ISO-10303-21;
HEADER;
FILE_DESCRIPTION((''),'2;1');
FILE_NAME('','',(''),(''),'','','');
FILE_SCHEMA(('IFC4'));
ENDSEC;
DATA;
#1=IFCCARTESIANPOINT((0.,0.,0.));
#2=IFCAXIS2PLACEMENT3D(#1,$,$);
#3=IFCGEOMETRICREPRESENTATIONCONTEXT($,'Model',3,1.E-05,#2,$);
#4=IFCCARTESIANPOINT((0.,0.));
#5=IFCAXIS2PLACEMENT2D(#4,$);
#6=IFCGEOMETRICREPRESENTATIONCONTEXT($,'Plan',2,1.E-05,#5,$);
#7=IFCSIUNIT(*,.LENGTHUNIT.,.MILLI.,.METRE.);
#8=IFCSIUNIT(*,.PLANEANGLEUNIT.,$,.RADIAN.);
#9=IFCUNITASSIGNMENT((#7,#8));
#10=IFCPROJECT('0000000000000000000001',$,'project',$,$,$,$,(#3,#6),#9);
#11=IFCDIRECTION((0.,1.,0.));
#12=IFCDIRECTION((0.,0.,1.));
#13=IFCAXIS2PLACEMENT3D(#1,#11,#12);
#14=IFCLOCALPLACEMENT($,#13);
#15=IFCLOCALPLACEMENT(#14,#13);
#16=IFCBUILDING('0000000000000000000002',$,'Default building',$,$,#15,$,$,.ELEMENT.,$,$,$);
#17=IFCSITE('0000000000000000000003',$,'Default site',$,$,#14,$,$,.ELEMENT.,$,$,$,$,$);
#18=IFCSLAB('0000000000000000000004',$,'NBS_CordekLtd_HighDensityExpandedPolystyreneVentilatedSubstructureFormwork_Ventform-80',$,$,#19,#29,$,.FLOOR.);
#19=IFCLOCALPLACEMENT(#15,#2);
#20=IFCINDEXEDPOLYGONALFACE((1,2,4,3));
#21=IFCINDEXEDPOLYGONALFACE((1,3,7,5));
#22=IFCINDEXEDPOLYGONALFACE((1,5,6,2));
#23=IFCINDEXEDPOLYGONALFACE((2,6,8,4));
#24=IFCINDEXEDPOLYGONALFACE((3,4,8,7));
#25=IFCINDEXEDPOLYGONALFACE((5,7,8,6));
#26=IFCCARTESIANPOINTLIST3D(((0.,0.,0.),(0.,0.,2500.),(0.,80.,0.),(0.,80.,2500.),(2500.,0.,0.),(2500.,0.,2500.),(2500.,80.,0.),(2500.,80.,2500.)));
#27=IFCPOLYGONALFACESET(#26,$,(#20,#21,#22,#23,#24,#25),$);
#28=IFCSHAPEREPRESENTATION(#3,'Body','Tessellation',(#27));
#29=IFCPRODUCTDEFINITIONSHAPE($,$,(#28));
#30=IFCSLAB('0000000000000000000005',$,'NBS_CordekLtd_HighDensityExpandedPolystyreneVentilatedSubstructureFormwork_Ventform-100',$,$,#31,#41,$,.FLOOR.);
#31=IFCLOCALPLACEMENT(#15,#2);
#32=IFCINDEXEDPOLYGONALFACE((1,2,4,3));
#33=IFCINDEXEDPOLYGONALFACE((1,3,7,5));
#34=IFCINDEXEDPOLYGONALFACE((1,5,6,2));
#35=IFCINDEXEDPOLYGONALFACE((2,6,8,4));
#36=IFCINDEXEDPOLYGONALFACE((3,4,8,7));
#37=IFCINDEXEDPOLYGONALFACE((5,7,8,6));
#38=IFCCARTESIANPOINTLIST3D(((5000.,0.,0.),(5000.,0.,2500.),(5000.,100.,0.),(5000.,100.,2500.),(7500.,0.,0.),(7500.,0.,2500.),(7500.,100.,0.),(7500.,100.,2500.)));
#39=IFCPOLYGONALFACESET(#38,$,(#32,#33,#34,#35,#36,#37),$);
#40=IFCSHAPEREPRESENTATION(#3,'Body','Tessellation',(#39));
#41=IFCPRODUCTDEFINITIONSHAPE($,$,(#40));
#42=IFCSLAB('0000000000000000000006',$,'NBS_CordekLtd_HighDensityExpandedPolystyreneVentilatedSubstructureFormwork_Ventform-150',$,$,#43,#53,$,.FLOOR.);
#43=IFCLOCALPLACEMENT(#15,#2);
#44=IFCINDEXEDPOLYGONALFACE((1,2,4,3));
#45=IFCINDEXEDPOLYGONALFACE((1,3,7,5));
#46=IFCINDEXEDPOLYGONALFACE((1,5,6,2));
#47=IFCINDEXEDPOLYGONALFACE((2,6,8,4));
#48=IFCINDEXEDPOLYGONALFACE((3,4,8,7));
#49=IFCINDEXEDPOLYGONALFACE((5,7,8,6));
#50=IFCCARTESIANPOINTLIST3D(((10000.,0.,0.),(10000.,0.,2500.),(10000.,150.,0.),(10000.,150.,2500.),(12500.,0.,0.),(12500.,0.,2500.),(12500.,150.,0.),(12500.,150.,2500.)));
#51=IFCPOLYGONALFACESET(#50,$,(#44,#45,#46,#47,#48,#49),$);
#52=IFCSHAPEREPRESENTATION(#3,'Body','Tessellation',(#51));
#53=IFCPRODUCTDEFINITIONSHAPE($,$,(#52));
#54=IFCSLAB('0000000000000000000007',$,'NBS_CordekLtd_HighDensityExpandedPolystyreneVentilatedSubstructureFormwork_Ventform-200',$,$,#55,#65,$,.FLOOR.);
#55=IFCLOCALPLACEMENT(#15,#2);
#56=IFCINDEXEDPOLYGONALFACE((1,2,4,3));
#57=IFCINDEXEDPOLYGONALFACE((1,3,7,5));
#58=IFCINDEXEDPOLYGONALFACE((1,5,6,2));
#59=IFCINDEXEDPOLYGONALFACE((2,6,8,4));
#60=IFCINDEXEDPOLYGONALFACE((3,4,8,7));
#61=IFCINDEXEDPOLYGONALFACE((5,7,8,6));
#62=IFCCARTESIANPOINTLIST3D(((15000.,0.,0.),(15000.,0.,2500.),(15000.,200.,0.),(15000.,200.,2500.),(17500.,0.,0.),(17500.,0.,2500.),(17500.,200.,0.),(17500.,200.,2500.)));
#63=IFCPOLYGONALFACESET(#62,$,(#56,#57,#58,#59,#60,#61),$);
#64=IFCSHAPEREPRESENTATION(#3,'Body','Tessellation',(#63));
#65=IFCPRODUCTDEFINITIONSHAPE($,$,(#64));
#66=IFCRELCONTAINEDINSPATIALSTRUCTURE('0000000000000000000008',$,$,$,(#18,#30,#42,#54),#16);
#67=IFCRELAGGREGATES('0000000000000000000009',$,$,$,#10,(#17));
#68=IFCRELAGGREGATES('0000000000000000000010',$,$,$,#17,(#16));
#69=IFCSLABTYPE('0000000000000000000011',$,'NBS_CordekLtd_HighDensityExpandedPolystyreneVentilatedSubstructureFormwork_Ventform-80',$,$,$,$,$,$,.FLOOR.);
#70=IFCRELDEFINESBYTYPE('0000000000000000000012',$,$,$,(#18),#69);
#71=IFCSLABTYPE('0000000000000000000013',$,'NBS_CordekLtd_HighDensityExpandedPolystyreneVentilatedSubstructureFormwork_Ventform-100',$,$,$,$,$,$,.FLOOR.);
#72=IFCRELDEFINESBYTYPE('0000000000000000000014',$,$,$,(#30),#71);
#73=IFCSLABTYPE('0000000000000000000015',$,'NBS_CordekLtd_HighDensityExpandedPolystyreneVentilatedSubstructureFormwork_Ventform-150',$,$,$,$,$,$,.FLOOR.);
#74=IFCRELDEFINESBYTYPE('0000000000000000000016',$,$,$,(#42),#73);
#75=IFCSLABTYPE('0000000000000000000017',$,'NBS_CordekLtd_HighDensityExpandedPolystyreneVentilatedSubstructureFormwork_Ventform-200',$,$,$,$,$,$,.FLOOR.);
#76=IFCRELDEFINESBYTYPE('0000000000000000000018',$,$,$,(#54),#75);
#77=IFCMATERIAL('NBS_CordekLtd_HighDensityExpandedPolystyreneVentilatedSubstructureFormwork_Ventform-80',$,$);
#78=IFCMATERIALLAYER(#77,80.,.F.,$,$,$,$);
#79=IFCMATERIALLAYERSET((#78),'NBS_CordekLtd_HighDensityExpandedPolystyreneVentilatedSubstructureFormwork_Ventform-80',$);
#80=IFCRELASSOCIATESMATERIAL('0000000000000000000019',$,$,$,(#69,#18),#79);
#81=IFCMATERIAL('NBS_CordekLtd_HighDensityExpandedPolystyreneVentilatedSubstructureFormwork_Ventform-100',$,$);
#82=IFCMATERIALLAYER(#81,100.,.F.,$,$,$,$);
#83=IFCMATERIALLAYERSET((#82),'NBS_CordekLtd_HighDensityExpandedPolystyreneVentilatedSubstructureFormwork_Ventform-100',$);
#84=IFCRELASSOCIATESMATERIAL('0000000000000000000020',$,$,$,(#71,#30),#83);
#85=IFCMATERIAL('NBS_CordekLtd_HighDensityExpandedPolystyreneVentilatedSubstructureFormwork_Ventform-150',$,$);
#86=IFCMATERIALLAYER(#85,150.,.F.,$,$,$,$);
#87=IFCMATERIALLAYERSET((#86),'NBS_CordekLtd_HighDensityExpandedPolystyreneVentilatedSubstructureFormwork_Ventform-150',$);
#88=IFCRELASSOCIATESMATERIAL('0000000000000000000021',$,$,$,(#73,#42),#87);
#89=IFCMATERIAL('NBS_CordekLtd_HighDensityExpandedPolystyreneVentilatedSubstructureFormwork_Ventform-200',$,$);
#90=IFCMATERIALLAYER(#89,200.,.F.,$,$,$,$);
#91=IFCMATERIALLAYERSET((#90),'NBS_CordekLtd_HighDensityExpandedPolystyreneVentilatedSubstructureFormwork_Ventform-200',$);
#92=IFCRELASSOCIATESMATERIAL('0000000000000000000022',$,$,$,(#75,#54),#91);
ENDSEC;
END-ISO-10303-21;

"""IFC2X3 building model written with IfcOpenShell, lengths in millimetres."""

from ifc_helpers import new_model, si_unit, frame, frame_2d, origin, origin_with_axes, origin_2d, place, context, project, spatial, rectangle, extrude, material, layer, layer_set, layer_usage, type_object, element, save


model = new_model("IFC2X3")

# Units and contexts
model_context = context("Model", 3, precision=1e-05, world=origin())
plan_context = context("Plan", 2, precision=1e-05, world=origin_2d())
ifc_project = project(units=[si_unit("LENGTHUNIT", "METRE", prefix="MILLI"), si_unit("PLANEANGLEUNIT", "RADIAN")], contexts=[model_context, plan_context])

# Site, building
site_placement = place(None, frame((0.0, 0.0, 0.0), z_axis=(0.0, 1.0, 0.0), x_axis=(0.0, 0.0, 1.0)))
site = spatial("IfcSite", under=ifc_project, at=site_placement, Name="Default site", CompositionType="ELEMENT")
building_placement = place(site_placement, frame((0.0, 0.0, 0.0), z_axis=(0.0, 1.0, 0.0), x_axis=(0.0, 0.0, 1.0)))
building = spatial("IfcBuilding", under=site, at=building_placement, Name="Default building", CompositionType="ELEMENT")

# Slabs
ifc_material_1 = material(Name="NBS_CordekLtd_HighDensityExpandedPolystyreneVentilatedSubstructureFormwork_Ventform-80")
ifc_layer_1 = layer(ifc_material_1, 80.0, ventilated=False)
ifc_layer_set_1 = layer_set([ifc_layer_1], Name="NBS_CordekLtd_HighDensityExpandedPolystyreneVentilatedSubstructureFormwork_Ventform-80")
ifc_layer_usage_1 = layer_usage(ifc_layer_set_1, "AXIS3", "NEGATIVE", 0.0)
slab_type_1 = type_object("IfcSlabType", Name="NBS_CordekLtd_HighDensityExpandedPolystyreneVentilatedSubstructureFormwork_Ventform-80", PredefinedType="FLOOR", material=ifc_layer_set_1)
slab_1_placement = place(None, origin())
element("IfcSlab", 1, at=slab_1_placement, inside=building, type_object=slab_type_1, material=ifc_layer_usage_1, Name="NBS_CordekLtd_HighDensityExpandedPolystyreneVentilatedSubstructureFormwork_Ventform-80", PredefinedType="FLOOR", context=model_context, shape_type="SweptSolid", body=[
    extrude(rectangle(XDim=2500.0, YDim=2500.0, at=frame_2d((1250.0, 1250.0))), origin_with_axes(), (0.0, 0.0, 1.0), 80.0),
])
ifc_material_2 = material(Name="NBS_CordekLtd_HighDensityExpandedPolystyreneVentilatedSubstructureFormwork_Ventform-100")
ifc_layer_2 = layer(ifc_material_2, 100.0, ventilated=False)
ifc_layer_set_2 = layer_set([ifc_layer_2], Name="NBS_CordekLtd_HighDensityExpandedPolystyreneVentilatedSubstructureFormwork_Ventform-100")
ifc_layer_usage_2 = layer_usage(ifc_layer_set_2, "AXIS3", "NEGATIVE", 0.0)
slab_type_2 = type_object("IfcSlabType", Name="NBS_CordekLtd_HighDensityExpandedPolystyreneVentilatedSubstructureFormwork_Ventform-100", PredefinedType="FLOOR", material=ifc_layer_set_2)
slab_2_placement = place(None, frame((0.0, 5000.0, 0.0)))
element("IfcSlab", 2, at=slab_2_placement, inside=building, type_object=slab_type_2, material=ifc_layer_usage_2, Name="NBS_CordekLtd_HighDensityExpandedPolystyreneVentilatedSubstructureFormwork_Ventform-100", PredefinedType="FLOOR", context=model_context, shape_type="SweptSolid", body=[
    extrude(rectangle(XDim=2500.0, YDim=2500.0, at=frame_2d((1250.0, 1250.0))), origin_with_axes(), (0.0, 0.0, 1.0), 100.0),
])
ifc_material_3 = material(Name="NBS_CordekLtd_HighDensityExpandedPolystyreneVentilatedSubstructureFormwork_Ventform-150")
ifc_layer_3 = layer(ifc_material_3, 150.0, ventilated=False)
ifc_layer_set_3 = layer_set([ifc_layer_3], Name="NBS_CordekLtd_HighDensityExpandedPolystyreneVentilatedSubstructureFormwork_Ventform-150")
ifc_layer_usage_3 = layer_usage(ifc_layer_set_3, "AXIS3", "NEGATIVE", 0.0)
slab_type_3 = type_object("IfcSlabType", Name="NBS_CordekLtd_HighDensityExpandedPolystyreneVentilatedSubstructureFormwork_Ventform-150", PredefinedType="FLOOR", material=ifc_layer_set_3)
slab_3_placement = place(None, frame((0.0, 10000.0, 0.0)))
element("IfcSlab", 3, at=slab_3_placement, inside=building, type_object=slab_type_3, material=ifc_layer_usage_3, Name="NBS_CordekLtd_HighDensityExpandedPolystyreneVentilatedSubstructureFormwork_Ventform-150", PredefinedType="FLOOR", context=model_context, shape_type="SweptSolid", body=[
    extrude(rectangle(XDim=2500.0, YDim=2500.0, at=frame_2d((1250.0, 1250.0))), origin_with_axes(), (0.0, 0.0, 1.0), 150.0),
])
ifc_material_4 = material(Name="NBS_CordekLtd_HighDensityExpandedPolystyreneVentilatedSubstructureFormwork_Ventform-200")
ifc_layer_4 = layer(ifc_material_4, 200.0, ventilated=False)
ifc_layer_set_4 = layer_set([ifc_layer_4], Name="NBS_CordekLtd_HighDensityExpandedPolystyreneVentilatedSubstructureFormwork_Ventform-200")
ifc_layer_usage_4 = layer_usage(ifc_layer_set_4, "AXIS3", "NEGATIVE", 0.0)
slab_type_4 = type_object("IfcSlabType", Name="NBS_CordekLtd_HighDensityExpandedPolystyreneVentilatedSubstructureFormwork_Ventform-200", PredefinedType="FLOOR", material=ifc_layer_set_4)
slab_4_placement = place(None, frame((0.0, 15000.0, 0.0)))
element("IfcSlab", 4, at=slab_4_placement, inside=building, type_object=slab_type_4, material=ifc_layer_usage_4, Name="NBS_CordekLtd_HighDensityExpandedPolystyreneVentilatedSubstructureFormwork_Ventform-200", PredefinedType="FLOOR", context=model_context, shape_type="SweptSolid", body=[
    extrude(rectangle(XDim=2500.0, YDim=2500.0, at=frame_2d((1250.0, 1250.0))), origin_with_axes(), (0.0, 0.0, 1.0), 200.0),
])

save(model, "model.ifc")
